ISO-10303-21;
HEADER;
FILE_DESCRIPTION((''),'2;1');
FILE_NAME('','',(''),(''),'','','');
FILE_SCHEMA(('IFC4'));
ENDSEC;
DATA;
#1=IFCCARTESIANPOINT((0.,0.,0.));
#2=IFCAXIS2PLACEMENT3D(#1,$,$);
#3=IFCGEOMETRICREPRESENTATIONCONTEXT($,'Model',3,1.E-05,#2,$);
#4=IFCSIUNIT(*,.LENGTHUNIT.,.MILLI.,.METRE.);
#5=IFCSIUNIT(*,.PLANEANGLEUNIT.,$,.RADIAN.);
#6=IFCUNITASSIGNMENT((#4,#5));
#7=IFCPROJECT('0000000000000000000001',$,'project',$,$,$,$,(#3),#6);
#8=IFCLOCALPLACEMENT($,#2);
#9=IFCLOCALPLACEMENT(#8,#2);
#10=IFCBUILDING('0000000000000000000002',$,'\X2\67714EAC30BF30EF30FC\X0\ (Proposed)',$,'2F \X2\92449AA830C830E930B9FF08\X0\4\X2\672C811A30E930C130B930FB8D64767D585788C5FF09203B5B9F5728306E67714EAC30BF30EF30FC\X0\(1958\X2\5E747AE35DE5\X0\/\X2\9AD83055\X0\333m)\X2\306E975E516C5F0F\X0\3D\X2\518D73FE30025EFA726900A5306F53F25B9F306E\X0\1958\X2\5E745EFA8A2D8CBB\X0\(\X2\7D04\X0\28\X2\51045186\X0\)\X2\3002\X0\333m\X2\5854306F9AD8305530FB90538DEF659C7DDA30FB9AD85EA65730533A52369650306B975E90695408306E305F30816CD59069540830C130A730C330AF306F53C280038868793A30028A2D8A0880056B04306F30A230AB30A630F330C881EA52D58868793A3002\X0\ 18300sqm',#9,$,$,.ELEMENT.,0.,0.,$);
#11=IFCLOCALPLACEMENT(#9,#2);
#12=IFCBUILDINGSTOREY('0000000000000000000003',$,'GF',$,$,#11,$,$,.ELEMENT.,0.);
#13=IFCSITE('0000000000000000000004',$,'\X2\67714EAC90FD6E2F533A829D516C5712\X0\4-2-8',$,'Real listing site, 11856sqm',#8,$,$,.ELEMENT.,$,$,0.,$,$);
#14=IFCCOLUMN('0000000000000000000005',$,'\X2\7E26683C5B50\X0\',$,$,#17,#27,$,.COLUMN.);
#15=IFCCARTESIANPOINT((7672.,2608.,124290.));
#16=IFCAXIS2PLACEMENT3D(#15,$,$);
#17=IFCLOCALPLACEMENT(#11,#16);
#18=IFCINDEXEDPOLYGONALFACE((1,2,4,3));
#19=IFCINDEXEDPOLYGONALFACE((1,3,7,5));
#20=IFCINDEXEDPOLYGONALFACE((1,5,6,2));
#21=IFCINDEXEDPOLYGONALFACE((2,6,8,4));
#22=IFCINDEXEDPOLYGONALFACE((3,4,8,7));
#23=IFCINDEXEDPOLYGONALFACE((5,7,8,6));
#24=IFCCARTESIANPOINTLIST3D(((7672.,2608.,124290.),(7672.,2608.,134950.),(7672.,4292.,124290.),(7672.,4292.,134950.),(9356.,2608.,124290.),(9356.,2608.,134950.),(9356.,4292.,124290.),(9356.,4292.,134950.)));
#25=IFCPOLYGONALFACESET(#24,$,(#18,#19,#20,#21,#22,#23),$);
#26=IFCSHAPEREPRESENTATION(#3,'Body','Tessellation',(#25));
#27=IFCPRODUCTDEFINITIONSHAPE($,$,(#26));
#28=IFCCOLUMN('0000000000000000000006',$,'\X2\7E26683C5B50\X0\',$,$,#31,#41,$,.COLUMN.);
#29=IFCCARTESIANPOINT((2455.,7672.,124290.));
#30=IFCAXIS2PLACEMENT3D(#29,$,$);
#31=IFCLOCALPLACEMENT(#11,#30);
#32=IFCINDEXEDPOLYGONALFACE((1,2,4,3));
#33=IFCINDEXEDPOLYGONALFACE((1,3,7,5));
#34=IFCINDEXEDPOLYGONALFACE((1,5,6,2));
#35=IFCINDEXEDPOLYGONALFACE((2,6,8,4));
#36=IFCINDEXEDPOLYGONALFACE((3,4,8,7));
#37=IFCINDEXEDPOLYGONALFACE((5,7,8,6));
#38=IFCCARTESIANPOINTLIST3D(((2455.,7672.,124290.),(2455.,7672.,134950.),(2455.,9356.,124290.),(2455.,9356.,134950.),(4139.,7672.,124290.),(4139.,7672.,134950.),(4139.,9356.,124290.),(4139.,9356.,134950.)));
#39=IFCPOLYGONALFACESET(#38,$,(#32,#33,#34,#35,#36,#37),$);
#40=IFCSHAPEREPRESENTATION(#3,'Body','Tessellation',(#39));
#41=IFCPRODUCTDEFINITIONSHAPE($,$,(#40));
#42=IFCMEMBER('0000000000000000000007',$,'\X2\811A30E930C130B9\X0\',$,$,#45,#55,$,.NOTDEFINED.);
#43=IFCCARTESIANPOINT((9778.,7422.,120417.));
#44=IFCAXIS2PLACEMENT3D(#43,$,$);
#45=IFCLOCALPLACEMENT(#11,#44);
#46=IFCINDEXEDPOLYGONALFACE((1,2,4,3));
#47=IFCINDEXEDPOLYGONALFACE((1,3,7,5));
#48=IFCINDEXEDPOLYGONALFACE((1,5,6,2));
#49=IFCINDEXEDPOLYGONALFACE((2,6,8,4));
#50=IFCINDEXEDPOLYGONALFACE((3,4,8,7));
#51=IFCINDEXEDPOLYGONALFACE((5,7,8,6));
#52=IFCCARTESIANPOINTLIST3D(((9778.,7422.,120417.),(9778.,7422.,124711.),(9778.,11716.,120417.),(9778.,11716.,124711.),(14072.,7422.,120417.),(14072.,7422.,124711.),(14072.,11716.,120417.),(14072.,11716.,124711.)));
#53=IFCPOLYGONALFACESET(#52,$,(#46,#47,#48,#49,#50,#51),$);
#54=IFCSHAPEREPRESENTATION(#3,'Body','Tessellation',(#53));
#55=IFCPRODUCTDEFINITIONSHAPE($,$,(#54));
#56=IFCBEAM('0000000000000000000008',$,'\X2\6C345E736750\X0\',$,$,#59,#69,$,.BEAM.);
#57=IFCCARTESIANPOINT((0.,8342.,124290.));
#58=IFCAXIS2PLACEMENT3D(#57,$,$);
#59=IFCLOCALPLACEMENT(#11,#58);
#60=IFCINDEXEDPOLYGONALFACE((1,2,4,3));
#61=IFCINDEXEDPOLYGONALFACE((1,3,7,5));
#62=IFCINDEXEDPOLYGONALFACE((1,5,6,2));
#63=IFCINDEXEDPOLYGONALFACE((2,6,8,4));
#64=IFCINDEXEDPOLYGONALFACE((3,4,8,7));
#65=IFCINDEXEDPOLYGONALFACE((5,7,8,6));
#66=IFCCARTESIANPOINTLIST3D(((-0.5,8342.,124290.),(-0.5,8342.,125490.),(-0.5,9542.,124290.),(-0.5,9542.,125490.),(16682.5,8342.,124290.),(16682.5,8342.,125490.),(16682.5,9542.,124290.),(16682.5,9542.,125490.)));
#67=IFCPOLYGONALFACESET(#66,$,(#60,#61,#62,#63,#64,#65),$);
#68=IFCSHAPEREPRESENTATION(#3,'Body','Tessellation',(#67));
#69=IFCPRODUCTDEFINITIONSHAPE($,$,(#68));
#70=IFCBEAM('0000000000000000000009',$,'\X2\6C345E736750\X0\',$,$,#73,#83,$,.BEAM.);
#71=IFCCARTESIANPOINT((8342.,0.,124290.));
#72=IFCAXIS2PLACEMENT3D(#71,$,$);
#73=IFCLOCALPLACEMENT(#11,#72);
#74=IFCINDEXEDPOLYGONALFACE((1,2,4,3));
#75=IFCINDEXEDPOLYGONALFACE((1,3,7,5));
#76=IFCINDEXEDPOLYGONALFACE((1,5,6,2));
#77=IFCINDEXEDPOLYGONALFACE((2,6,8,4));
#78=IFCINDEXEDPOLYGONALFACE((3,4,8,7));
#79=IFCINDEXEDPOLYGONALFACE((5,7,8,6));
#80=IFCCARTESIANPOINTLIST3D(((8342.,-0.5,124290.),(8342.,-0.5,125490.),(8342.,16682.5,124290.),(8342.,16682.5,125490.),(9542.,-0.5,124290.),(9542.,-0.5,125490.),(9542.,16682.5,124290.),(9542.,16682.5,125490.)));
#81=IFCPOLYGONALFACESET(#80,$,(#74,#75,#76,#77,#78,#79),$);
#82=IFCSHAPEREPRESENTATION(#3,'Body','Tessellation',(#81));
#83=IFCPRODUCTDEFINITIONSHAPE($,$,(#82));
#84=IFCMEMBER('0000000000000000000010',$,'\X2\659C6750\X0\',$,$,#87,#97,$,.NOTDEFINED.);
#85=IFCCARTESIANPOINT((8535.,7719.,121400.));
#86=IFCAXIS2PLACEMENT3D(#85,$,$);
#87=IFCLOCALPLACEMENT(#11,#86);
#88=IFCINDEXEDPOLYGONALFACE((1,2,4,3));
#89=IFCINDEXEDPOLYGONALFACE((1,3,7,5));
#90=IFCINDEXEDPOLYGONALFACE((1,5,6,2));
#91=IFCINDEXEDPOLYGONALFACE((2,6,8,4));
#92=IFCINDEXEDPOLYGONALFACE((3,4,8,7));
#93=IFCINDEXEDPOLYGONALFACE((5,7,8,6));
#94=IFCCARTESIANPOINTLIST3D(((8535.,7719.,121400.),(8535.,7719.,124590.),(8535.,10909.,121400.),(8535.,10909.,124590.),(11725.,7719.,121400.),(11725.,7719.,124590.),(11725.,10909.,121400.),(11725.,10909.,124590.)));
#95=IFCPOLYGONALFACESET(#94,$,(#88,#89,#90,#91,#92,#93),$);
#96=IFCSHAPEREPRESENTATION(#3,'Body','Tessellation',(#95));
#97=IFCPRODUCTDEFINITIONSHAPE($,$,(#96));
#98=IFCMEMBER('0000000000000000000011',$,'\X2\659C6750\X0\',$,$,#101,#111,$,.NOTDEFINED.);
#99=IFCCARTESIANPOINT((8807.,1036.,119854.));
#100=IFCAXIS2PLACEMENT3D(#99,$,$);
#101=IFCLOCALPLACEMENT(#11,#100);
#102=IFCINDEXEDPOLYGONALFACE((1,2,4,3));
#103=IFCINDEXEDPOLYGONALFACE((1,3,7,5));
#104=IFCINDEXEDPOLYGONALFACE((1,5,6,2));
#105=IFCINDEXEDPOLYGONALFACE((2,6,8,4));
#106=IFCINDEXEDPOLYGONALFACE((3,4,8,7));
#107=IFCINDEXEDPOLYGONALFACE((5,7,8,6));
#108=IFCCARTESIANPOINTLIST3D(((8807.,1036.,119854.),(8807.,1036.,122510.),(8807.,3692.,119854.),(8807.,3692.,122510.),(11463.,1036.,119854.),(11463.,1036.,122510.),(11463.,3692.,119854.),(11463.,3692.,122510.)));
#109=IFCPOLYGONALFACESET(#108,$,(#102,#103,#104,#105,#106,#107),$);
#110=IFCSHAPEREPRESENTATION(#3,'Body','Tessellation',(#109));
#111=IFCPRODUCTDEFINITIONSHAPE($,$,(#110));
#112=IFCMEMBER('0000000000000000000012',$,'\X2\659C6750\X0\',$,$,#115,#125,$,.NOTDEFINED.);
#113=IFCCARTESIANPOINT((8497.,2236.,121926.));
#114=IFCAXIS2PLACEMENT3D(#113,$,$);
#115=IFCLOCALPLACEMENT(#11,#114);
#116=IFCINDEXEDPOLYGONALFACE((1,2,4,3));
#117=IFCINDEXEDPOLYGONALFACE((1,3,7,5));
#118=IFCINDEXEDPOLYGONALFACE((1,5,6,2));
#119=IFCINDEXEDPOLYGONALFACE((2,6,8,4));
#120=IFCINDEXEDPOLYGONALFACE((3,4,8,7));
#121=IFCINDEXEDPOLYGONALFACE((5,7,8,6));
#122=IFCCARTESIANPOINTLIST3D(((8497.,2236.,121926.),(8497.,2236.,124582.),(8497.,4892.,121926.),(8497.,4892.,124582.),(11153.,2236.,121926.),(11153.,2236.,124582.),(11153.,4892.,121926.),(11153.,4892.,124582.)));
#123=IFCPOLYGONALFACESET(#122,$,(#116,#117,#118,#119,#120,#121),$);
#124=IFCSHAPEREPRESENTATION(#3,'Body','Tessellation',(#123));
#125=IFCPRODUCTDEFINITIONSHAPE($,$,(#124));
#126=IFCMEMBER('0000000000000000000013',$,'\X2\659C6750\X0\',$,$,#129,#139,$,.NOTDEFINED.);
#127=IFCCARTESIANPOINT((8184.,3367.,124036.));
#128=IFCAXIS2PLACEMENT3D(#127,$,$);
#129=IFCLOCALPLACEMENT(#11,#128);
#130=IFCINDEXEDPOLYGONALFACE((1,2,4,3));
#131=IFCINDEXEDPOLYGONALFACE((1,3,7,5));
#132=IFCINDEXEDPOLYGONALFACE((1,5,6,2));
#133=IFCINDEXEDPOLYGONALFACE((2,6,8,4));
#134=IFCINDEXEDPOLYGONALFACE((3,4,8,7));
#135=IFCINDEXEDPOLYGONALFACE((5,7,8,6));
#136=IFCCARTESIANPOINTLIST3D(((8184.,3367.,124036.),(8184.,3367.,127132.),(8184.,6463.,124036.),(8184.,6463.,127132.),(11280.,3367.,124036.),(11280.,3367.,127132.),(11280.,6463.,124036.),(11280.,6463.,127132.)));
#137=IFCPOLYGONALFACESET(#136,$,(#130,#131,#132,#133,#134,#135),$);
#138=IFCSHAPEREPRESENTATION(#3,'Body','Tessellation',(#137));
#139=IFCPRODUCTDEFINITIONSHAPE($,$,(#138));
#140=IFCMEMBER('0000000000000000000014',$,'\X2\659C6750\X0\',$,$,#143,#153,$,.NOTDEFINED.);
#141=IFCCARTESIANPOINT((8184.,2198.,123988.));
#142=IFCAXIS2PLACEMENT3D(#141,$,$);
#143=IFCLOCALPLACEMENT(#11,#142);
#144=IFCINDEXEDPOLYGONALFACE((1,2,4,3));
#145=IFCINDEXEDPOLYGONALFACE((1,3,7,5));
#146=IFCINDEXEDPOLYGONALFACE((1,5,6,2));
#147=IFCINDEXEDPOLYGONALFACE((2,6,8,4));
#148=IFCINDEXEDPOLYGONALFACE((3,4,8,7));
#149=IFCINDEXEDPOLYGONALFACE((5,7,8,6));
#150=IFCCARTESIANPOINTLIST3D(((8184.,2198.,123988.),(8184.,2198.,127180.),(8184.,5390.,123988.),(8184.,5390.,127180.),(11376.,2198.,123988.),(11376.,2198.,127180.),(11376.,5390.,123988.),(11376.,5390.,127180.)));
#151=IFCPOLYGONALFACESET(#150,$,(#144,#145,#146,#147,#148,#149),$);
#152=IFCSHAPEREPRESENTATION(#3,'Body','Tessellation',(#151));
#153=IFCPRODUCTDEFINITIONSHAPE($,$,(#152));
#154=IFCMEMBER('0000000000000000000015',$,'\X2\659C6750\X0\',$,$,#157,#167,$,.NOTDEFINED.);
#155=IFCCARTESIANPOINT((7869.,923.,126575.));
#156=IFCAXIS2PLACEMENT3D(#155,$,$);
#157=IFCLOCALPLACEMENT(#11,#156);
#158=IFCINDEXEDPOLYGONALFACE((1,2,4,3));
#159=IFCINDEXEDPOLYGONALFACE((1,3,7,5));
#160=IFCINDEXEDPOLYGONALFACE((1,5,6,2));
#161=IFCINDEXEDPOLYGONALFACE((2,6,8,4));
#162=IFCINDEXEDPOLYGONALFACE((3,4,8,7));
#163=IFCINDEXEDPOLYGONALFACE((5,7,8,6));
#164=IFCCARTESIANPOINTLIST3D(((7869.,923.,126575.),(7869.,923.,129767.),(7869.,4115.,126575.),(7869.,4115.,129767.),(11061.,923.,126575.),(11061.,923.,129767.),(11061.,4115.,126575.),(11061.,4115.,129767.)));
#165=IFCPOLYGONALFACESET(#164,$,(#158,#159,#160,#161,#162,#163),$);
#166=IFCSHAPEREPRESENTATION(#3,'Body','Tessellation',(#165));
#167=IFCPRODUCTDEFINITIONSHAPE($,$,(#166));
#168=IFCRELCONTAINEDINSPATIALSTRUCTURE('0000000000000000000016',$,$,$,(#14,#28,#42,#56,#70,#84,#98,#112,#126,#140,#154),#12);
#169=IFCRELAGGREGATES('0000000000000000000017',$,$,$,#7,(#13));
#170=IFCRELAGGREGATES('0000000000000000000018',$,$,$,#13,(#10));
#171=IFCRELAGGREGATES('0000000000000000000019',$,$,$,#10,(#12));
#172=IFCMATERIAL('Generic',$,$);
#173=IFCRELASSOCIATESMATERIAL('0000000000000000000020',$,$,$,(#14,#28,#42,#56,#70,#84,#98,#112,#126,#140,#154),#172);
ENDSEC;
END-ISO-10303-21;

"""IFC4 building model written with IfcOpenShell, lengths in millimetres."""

from ifc_helpers import new_model, si_unit, frame, frame_2d, origin, place, context, project, spatial, rectangle, extrude, material, element, save


model = new_model("IFC4")

# Units and contexts
model_context = context("Model", 3, precision=1e-05, world=origin())
ifc_project = project(units=[si_unit("LENGTHUNIT", "METRE", prefix="MILLI"), si_unit("PLANEANGLEUNIT", "RADIAN")], contexts=[model_context])

# Site, building, storey
site_placement = place(None, origin())
site = spatial("IfcSite", under=ifc_project, at=site_placement, Name="東京都港区芝公園4-2-8", ObjectType="Real listing site, 11856sqm", CompositionType="ELEMENT", RefElevation=0.0)
building_placement = place(site_placement, origin())
building = spatial("IfcBuilding", under=site, at=building_placement, Name="東京タワー (Proposed)", ObjectType="2F 鉄骨トラス（4本脚ラチス・赤白塗装）※実在の東京タワー(1958年竣工/高さ333m)の非公式3D再現。建物¥は史実の1958年建設費(約28億円)。333m塔は高さ・道路斜線・高度地区制限に非適合のため法適合チェックは参考表示。設計者欄はアカウント自動表示。 18300sqm", CompositionType="ELEMENT", ElevationOfRefHeight=0.0, ElevationOfTerrain=0.0)
storey_placement = place(building_placement, origin())
storey = spatial("IfcBuildingStorey", under=building, at=storey_placement, Name="GF", CompositionType="ELEMENT", Elevation=0.0)

# Columns
ifc_material = material(Name="Generic")
column_1_placement = place(storey_placement, frame((7672.0, 2608.0, 124290.0)))
element("IfcColumn", 1, at=column_1_placement, inside=storey, material=ifc_material, Name="縦格子", PredefinedType="COLUMN", context=model_context, shape_type="SweptSolid", body=[
    extrude(rectangle(XDim=1684.0, YDim=1684.0, at=frame_2d((842.0, 842.0))), frame((7672.0, 2608.0, 124290.0)), (0.0, 0.0, 1.0), 10660.0),
])
column_2_placement = place(storey_placement, frame((2455.0, 7672.0, 124290.0)))
element("IfcColumn", 2, at=column_2_placement, inside=storey, material=ifc_material, Name="縦格子", PredefinedType="COLUMN", context=model_context, shape_type="SweptSolid", body=[
    extrude(rectangle(XDim=1684.0, YDim=1684.0, at=frame_2d((842.0, 842.0))), frame((2455.0, 7672.0, 124290.0)), (0.0, 0.0, 1.0), 10660.0),
])

# Member
member_1_placement = place(storey_placement, frame((9778.0, 7422.0, 120417.0)))
element("IfcMember", 3, at=member_1_placement, inside=storey, material=ifc_material, Name="脚ラチス", PredefinedType="NOTDEFINED", context=model_context, shape_type="SweptSolid", body=[
    extrude(rectangle(XDim=4294.0, YDim=4294.0, at=frame_2d((2147.0, 2147.0))), frame((9778.0, 7422.0, 120417.0)), (0.0, 0.0, 1.0), 4294.0),
])

# Beams
beam_1_placement = place(storey_placement, frame((0.0, 8342.0, 124290.0)))
element("IfcBeam", 4, at=beam_1_placement, inside=storey, material=ifc_material, Name="水平材", PredefinedType="BEAM", context=model_context, shape_type="SweptSolid", body=[
    extrude(rectangle(XDim=16683.0, YDim=1200.0, at=frame_2d((8341.0, 600.0))), frame((0.0, 8342.0, 124290.0)), (0.0, 0.0, 1.0), 1200.0),
])
beam_2_placement = place(storey_placement, frame((8342.0, 0.0, 124290.0)))
element("IfcBeam", 5, at=beam_2_placement, inside=storey, material=ifc_material, Name="水平材", PredefinedType="BEAM", context=model_context, shape_type="SweptSolid", body=[
    extrude(rectangle(XDim=1200.0, YDim=16683.0, at=frame_2d((600.0, 8341.0))), frame((8342.0, 0.0, 124290.0)), (0.0, 0.0, 1.0), 1200.0),
])

# Members
member_2_placement = place(storey_placement, frame((8535.0, 7719.0, 121400.0)))
element("IfcMember", 6, at=member_2_placement, inside=storey, material=ifc_material, Name="斜材", PredefinedType="NOTDEFINED", context=model_context, shape_type="SweptSolid", body=[
    extrude(rectangle(XDim=3190.0, YDim=3190.0, at=frame_2d((1595.0, 1595.0))), frame((8535.0, 7719.0, 121400.0)), (0.0, 0.0, 1.0), 3190.0),
])
member_3_placement = place(storey_placement, frame((8807.0, 1036.0, 119854.0)))
element("IfcMember", 7, at=member_3_placement, inside=storey, material=ifc_material, Name="斜材", PredefinedType="NOTDEFINED", context=model_context, shape_type="SweptSolid", body=[
    extrude(rectangle(XDim=2656.0, YDim=2656.0, at=frame_2d((1328.0, 1328.0))), frame((8807.0, 1036.0, 119854.0)), (0.0, 0.0, 1.0), 2656.0),
])
member_4_placement = place(storey_placement, frame((8497.0, 2236.0, 121926.0)))
element("IfcMember", 8, at=member_4_placement, inside=storey, material=ifc_material, Name="斜材", PredefinedType="NOTDEFINED", context=model_context, shape_type="SweptSolid", body=[
    extrude(rectangle(XDim=2656.0, YDim=2656.0, at=frame_2d((1328.0, 1328.0))), frame((8497.0, 2236.0, 121926.0)), (0.0, 0.0, 1.0), 2656.0),
])
member_5_placement = place(storey_placement, frame((8184.0, 3367.0, 124036.0)))
element("IfcMember", 9, at=member_5_placement, inside=storey, material=ifc_material, Name="斜材", PredefinedType="NOTDEFINED", context=model_context, shape_type="SweptSolid", body=[
    extrude(rectangle(XDim=3096.0, YDim=3096.0, at=frame_2d((1548.0, 1548.0))), frame((8184.0, 3367.0, 124036.0)), (0.0, 0.0, 1.0), 3096.0),
])
member_6_placement = place(storey_placement, frame((8184.0, 2198.0, 123988.0)))
element("IfcMember", 10, at=member_6_placement, inside=storey, material=ifc_material, Name="斜材", PredefinedType="NOTDEFINED", context=model_context, shape_type="SweptSolid", body=[
    extrude(rectangle(XDim=3192.0, YDim=3192.0, at=frame_2d((1596.0, 1596.0))), frame((8184.0, 2198.0, 123988.0)), (0.0, 0.0, 1.0), 3192.0),
])
member_7_placement = place(storey_placement, frame((7869.0, 923.0, 126575.0)))
element("IfcMember", 11, at=member_7_placement, inside=storey, material=ifc_material, Name="斜材", PredefinedType="NOTDEFINED", context=model_context, shape_type="SweptSolid", body=[
    extrude(rectangle(XDim=3192.0, YDim=3192.0, at=frame_2d((1596.0, 1596.0))), frame((7869.0, 923.0, 126575.0)), (0.0, 0.0, 1.0), 3192.0),
])

save(model, "model.ifc")
